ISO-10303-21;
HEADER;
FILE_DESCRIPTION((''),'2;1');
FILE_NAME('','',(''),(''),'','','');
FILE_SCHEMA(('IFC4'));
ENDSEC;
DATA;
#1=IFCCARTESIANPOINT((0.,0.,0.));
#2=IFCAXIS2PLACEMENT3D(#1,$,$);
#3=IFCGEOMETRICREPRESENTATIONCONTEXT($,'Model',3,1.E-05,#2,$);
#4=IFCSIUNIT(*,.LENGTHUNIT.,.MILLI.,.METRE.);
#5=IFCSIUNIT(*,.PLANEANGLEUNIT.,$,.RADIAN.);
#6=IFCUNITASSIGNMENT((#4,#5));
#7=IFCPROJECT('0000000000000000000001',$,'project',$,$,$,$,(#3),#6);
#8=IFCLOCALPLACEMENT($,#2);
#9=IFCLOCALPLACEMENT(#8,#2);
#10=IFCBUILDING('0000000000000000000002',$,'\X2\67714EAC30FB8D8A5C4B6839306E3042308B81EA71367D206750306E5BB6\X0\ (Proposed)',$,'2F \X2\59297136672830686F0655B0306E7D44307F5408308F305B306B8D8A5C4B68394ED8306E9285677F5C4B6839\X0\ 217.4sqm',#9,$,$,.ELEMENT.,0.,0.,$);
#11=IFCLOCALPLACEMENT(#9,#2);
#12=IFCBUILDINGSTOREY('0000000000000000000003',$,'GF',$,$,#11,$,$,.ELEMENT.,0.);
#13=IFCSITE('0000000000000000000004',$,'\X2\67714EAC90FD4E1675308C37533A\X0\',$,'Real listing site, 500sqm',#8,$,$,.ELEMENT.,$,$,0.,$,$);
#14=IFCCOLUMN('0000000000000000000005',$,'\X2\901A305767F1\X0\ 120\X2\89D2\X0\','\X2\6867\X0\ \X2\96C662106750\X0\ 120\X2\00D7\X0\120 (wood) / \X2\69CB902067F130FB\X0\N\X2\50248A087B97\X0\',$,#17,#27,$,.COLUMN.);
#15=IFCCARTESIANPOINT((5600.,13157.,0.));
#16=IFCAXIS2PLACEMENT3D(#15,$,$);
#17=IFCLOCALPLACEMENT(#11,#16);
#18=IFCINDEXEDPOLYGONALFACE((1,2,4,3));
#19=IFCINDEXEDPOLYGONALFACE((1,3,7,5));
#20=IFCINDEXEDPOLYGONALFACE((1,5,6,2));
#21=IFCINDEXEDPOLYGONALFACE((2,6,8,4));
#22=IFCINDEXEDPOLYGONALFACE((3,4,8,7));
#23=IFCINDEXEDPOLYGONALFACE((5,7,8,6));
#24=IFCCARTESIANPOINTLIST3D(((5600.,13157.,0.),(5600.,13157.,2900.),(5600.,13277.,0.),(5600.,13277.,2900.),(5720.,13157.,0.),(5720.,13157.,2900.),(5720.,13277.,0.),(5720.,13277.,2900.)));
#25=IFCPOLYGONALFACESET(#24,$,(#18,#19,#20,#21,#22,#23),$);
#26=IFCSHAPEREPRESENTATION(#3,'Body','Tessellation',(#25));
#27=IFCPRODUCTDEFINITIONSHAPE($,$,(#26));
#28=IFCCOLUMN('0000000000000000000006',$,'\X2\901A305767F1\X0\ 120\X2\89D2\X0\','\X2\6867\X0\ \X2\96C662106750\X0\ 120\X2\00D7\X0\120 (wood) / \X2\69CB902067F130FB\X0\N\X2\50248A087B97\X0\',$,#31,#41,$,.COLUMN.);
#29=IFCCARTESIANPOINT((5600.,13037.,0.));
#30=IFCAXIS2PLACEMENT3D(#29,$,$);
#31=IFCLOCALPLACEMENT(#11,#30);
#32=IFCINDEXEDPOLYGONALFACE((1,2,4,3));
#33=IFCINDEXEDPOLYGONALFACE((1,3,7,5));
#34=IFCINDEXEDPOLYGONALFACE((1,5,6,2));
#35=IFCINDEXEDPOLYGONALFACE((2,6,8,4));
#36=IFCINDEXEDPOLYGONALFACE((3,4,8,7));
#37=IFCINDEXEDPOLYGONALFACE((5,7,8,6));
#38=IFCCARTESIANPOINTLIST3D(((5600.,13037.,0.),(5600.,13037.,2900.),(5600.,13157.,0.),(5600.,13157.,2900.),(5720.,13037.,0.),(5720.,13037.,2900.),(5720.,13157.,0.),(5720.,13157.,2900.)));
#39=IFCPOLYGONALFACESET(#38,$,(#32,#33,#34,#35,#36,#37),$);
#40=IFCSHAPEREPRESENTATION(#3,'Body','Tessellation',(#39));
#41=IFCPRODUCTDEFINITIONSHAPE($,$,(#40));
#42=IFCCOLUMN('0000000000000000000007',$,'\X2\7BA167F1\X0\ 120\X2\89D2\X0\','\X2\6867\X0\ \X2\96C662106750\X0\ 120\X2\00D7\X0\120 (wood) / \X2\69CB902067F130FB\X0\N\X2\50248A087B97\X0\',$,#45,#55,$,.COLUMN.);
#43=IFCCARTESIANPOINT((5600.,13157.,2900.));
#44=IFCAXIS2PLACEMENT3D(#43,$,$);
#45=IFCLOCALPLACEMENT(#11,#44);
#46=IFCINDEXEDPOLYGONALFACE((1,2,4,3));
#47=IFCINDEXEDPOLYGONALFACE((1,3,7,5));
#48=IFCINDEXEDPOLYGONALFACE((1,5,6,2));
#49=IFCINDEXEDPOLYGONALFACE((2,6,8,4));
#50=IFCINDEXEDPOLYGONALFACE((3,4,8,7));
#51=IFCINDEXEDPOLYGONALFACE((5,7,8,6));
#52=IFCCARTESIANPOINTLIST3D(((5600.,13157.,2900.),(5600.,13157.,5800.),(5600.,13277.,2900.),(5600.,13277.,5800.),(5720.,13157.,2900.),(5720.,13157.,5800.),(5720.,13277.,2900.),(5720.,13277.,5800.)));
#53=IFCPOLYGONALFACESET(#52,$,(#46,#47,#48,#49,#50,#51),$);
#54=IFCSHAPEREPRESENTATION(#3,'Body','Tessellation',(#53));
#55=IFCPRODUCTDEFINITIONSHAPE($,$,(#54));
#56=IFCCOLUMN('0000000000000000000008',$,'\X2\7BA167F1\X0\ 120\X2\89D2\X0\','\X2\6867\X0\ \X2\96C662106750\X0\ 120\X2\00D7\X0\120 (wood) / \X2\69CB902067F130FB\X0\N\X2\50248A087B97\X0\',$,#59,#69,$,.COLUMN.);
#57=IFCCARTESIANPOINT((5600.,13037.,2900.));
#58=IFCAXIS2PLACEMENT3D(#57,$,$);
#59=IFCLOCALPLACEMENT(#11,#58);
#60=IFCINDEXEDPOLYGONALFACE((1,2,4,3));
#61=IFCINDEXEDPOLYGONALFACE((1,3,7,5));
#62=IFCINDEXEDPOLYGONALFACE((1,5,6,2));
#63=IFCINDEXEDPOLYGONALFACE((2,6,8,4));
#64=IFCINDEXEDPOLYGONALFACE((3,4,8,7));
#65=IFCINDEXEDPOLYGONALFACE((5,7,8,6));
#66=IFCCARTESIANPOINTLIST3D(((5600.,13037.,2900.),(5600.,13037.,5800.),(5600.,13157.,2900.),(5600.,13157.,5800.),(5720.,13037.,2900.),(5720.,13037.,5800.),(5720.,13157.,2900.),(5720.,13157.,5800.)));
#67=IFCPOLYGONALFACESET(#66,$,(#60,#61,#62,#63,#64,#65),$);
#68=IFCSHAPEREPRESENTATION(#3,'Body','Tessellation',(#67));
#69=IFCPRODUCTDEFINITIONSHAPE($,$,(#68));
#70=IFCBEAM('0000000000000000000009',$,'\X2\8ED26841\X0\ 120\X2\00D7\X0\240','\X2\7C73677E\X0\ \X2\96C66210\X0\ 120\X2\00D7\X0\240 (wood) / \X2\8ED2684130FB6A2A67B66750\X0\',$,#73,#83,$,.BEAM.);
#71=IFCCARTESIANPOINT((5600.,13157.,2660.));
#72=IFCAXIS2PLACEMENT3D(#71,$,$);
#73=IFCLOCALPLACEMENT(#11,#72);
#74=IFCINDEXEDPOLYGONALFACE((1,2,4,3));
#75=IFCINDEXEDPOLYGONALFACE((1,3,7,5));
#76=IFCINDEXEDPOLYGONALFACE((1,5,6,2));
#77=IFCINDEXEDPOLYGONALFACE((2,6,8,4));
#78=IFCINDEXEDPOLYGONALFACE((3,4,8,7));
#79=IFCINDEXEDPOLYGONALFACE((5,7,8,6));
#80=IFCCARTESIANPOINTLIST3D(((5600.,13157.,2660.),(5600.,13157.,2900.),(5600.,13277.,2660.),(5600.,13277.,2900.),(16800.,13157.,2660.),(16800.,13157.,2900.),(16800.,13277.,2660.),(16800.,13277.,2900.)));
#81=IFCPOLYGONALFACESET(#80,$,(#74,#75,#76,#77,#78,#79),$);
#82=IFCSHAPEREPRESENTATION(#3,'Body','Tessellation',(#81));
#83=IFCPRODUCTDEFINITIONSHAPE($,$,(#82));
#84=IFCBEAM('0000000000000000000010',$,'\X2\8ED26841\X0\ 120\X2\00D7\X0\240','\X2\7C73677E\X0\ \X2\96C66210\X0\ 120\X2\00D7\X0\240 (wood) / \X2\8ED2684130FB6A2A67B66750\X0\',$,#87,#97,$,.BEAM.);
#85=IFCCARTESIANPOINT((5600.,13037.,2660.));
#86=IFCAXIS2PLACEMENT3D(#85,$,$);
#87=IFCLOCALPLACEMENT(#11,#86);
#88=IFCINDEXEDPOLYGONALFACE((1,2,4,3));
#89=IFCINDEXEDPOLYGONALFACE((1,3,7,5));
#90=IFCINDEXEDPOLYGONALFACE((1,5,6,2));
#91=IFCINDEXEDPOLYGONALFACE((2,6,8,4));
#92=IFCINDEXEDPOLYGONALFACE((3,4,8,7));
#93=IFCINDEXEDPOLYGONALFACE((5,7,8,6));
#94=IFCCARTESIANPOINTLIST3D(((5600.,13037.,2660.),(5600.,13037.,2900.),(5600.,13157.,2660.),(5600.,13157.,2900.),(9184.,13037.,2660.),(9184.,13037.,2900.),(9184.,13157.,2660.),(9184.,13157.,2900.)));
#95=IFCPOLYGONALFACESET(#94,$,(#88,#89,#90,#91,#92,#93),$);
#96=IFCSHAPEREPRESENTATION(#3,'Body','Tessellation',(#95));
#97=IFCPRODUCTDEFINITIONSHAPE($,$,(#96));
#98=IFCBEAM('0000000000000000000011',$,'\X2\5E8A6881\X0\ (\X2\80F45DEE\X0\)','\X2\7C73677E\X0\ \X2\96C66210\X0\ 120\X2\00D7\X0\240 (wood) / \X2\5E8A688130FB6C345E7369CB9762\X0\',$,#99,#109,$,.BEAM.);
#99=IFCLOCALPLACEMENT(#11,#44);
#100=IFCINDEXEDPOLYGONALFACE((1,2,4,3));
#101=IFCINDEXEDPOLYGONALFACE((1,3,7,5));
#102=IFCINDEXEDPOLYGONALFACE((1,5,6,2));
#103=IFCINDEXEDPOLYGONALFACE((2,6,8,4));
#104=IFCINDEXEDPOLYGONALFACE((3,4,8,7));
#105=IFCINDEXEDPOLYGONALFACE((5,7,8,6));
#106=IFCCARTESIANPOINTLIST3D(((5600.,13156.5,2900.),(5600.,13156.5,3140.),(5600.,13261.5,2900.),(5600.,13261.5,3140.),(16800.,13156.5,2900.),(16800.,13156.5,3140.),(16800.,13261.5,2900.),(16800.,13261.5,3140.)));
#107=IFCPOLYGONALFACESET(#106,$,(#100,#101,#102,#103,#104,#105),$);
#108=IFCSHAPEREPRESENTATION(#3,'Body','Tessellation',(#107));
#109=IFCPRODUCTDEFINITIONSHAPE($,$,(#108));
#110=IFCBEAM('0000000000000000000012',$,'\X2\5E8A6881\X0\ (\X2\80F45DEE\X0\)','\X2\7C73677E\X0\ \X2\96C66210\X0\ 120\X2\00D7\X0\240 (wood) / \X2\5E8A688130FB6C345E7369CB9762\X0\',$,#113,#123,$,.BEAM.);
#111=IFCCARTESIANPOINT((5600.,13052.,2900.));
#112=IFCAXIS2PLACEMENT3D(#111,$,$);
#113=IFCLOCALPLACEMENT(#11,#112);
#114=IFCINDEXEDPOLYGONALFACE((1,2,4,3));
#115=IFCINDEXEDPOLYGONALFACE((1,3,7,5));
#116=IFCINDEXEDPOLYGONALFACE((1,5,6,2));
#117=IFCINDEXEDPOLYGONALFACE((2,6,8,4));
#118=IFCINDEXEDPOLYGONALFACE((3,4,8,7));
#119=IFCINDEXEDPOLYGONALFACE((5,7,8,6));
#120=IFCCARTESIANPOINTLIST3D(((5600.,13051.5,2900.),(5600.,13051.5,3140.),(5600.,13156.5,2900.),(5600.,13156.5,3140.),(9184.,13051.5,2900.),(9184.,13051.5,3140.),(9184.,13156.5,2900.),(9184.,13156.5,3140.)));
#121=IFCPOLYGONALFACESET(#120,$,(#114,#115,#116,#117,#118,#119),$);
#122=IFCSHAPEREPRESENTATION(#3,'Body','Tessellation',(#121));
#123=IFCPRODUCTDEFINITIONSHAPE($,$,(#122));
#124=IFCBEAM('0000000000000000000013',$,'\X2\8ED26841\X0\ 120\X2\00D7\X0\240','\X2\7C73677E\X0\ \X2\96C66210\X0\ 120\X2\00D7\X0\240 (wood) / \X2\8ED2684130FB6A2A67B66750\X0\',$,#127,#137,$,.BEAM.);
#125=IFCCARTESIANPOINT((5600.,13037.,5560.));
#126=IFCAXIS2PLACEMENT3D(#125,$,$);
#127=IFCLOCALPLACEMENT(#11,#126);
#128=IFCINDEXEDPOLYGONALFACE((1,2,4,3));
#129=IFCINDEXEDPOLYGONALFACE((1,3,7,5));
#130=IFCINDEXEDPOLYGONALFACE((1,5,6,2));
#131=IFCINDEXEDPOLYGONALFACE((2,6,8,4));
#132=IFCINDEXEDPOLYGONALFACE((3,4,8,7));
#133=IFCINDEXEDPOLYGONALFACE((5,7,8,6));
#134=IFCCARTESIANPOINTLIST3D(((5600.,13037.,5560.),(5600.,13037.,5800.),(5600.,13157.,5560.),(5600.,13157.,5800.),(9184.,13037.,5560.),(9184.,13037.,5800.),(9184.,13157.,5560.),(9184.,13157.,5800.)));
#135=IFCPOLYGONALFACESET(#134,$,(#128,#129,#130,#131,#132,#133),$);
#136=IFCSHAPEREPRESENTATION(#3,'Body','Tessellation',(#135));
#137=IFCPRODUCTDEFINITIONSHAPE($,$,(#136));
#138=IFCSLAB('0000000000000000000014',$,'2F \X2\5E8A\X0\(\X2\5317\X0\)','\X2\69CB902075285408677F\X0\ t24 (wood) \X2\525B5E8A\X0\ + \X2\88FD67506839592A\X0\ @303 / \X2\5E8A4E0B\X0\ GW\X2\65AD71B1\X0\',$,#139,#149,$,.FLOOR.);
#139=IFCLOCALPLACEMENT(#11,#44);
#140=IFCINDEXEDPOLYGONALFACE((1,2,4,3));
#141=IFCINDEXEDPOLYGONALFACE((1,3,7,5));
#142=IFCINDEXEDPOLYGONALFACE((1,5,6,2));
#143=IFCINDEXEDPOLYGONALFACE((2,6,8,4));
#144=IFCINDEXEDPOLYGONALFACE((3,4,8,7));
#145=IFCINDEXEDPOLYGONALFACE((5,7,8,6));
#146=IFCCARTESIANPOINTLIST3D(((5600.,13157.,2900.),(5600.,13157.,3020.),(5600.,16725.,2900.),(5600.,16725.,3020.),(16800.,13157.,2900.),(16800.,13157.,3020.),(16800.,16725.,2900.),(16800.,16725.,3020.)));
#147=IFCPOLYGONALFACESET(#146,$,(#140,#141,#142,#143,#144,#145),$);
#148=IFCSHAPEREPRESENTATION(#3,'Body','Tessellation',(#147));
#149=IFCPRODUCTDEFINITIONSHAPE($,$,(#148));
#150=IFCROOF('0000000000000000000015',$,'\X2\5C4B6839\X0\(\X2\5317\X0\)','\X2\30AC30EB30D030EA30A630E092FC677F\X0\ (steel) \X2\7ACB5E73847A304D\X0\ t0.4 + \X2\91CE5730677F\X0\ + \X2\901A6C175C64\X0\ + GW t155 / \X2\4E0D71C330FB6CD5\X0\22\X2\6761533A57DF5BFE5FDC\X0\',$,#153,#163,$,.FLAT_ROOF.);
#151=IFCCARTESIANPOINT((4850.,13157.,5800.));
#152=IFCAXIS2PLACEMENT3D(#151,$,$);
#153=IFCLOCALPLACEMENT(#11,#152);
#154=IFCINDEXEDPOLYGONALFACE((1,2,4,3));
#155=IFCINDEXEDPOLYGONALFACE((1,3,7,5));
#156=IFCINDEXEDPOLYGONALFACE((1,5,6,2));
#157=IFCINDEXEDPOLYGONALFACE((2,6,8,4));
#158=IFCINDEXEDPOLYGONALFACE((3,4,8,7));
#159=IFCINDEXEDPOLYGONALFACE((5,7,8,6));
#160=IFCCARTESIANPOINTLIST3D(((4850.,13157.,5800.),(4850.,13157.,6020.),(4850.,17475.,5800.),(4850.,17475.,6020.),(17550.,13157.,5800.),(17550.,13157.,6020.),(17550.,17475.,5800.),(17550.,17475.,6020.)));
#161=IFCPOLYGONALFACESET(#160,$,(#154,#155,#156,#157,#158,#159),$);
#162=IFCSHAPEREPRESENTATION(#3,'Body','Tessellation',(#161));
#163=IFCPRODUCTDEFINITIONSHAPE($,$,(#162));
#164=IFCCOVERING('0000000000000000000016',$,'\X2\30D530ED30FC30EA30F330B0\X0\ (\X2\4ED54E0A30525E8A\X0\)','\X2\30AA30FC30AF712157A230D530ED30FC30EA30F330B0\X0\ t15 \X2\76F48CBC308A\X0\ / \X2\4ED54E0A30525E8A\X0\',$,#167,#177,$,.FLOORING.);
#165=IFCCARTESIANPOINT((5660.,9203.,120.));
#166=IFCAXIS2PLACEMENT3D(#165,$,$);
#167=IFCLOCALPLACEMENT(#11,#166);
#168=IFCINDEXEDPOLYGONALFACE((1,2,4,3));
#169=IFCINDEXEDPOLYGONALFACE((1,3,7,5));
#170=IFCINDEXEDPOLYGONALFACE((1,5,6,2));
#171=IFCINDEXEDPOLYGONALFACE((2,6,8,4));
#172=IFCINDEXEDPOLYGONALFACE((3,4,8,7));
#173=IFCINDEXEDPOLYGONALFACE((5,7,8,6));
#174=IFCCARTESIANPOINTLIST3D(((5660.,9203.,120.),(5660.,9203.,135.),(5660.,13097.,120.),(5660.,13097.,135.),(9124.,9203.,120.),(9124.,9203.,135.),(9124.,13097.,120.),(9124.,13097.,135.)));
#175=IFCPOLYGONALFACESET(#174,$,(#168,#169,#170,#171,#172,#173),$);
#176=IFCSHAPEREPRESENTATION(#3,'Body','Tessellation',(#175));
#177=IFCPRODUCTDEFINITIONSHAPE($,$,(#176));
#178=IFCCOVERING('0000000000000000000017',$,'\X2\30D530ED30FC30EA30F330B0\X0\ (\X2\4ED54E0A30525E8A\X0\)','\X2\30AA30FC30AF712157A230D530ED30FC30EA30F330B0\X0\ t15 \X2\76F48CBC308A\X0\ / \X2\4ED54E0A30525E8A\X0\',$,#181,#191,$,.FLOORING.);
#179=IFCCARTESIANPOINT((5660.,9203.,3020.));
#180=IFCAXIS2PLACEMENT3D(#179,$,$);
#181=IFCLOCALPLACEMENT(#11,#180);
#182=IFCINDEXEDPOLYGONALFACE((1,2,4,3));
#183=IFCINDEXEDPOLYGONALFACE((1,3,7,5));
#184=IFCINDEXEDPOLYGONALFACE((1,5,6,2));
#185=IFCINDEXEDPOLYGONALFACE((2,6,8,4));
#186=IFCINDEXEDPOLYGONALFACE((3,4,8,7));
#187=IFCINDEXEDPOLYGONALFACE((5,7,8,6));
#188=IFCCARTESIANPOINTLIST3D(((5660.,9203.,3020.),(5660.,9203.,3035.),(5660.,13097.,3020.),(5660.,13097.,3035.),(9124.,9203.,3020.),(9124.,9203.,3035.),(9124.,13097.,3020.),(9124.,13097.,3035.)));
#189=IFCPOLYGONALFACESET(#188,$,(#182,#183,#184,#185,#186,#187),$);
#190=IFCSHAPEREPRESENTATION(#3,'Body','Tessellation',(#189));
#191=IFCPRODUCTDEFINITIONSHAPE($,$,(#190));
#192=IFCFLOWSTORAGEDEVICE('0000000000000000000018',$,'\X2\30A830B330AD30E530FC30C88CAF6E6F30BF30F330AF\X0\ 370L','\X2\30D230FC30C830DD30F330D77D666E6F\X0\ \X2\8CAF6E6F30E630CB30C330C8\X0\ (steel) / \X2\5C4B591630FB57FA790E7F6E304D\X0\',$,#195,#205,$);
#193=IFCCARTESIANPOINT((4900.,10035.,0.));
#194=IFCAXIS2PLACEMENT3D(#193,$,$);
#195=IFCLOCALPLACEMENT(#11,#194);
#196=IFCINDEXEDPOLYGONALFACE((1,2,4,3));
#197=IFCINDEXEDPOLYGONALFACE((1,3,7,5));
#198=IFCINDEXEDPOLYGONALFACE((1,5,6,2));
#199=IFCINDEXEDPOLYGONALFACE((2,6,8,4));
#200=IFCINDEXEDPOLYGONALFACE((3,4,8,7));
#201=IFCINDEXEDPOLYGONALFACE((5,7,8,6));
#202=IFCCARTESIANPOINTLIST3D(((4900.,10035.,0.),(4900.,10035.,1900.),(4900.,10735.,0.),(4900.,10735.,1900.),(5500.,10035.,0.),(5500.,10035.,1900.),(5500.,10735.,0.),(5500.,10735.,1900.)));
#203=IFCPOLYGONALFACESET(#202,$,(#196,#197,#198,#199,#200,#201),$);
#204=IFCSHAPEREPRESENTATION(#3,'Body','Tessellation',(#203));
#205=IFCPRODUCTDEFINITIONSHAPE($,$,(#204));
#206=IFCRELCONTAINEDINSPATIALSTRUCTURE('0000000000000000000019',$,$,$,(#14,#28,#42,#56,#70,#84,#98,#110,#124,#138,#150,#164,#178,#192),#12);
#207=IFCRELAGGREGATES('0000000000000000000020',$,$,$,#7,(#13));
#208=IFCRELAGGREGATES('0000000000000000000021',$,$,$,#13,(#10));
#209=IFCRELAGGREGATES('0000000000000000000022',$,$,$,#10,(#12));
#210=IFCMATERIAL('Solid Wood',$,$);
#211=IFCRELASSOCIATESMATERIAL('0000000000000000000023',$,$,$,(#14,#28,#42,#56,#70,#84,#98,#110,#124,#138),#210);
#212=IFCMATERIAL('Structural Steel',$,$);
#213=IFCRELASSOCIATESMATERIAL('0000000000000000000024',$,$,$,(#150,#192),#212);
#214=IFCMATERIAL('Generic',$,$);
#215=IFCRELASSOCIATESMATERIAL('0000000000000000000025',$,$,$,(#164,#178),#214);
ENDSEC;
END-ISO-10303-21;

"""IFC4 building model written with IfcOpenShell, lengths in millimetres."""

from ifc_helpers import new_model, si_unit, frame, frame_2d, origin, place, context, project, spatial, rectangle, extrude, material, element, save


model = new_model("IFC4")

# Units and contexts
model_context = context("Model", 3, precision=1e-05, world=origin())
ifc_project = project(units=[si_unit("LENGTHUNIT", "METRE", prefix="MILLI"), si_unit("PLANEANGLEUNIT", "RADIAN")], contexts=[model_context])

# Site, building, storey
site_placement = place(None, origin())
site = spatial("IfcSite", under=ifc_project, at=site_placement, Name="東京都世田谷区", ObjectType="Real listing site, 500sqm", CompositionType="ELEMENT", RefElevation=0.0)
building_placement = place(site_placement, origin())
building = spatial("IfcBuilding", under=site, at=building_placement, Name="東京・越屋根のある自然素材の家 (Proposed)", ObjectType="2F 天然木と漆喰の組み合わせに越屋根付の銅板屋根 217.4sqm", CompositionType="ELEMENT", ElevationOfRefHeight=0.0, ElevationOfTerrain=0.0)
storey_placement = place(building_placement, origin())
storey = spatial("IfcBuildingStorey", under=building, at=storey_placement, Name="GF", CompositionType="ELEMENT", Elevation=0.0)

# Columns
ifc_material_1 = material(Name="Solid Wood")
column_1_placement = place(storey_placement, frame((5600.0, 13157.0, 0.0)))
element("IfcColumn", 1, at=column_1_placement, inside=storey, material=ifc_material_1, Name="通し柱 120角", Description="桧 集成材 120×120 (wood) / 構造柱・N値計算", PredefinedType="COLUMN", context=model_context, shape_type="SweptSolid", body=[
    extrude(rectangle(XDim=120.0, YDim=120.0, at=frame_2d((60.0, 60.0))), frame((5600.0, 13157.0, 0.0)), (0.0, 0.0, 1.0), 2900.0),
])
column_2_placement = place(storey_placement, frame((5600.0, 13037.0, 0.0)))
element("IfcColumn", 2, at=column_2_placement, inside=storey, material=ifc_material_1, Name="通し柱 120角", Description="桧 集成材 120×120 (wood) / 構造柱・N値計算", PredefinedType="COLUMN", context=model_context, shape_type="SweptSolid", body=[
    extrude(rectangle(XDim=120.0, YDim=120.0, at=frame_2d((60.0, 60.0))), frame((5600.0, 13037.0, 0.0)), (0.0, 0.0, 1.0), 2900.0),
])
column_3_placement = place(storey_placement, frame((5600.0, 13157.0, 2900.0)))
element("IfcColumn", 3, at=column_3_placement, inside=storey, material=ifc_material_1, Name="管柱 120角", Description="桧 集成材 120×120 (wood) / 構造柱・N値計算", PredefinedType="COLUMN", context=model_context, shape_type="SweptSolid", body=[
    extrude(rectangle(XDim=120.0, YDim=120.0, at=frame_2d((60.0, 60.0))), frame((5600.0, 13157.0, 2900.0)), (0.0, 0.0, 1.0), 2900.0),
])
column_4_placement = place(storey_placement, frame((5600.0, 13037.0, 2900.0)))
element("IfcColumn", 4, at=column_4_placement, inside=storey, material=ifc_material_1, Name="管柱 120角", Description="桧 集成材 120×120 (wood) / 構造柱・N値計算", PredefinedType="COLUMN", context=model_context, shape_type="SweptSolid", body=[
    extrude(rectangle(XDim=120.0, YDim=120.0, at=frame_2d((60.0, 60.0))), frame((5600.0, 13037.0, 2900.0)), (0.0, 0.0, 1.0), 2900.0),
])

# Beams
beam_1_placement = place(storey_placement, frame((5600.0, 13157.0, 2660.0)))
element("IfcBeam", 5, at=beam_1_placement, inside=storey, material=ifc_material_1, Name="軒桁 120×240", Description="米松 集成 120×240 (wood) / 軒桁・横架材", PredefinedType="BEAM", context=model_context, shape_type="SweptSolid", body=[
    extrude(rectangle(XDim=11200.0, YDim=120.0, at=frame_2d((5600.0, 60.0))), frame((5600.0, 13157.0, 2660.0)), (0.0, 0.0, 1.0), 240.0),
])
beam_2_placement = place(storey_placement, frame((5600.0, 13037.0, 2660.0)))
element("IfcBeam", 6, at=beam_2_placement, inside=storey, material=ifc_material_1, Name="軒桁 120×240", Description="米松 集成 120×240 (wood) / 軒桁・横架材", PredefinedType="BEAM", context=model_context, shape_type="SweptSolid", body=[
    extrude(rectangle(XDim=3584.0, YDim=120.0, at=frame_2d((1792.0, 60.0))), frame((5600.0, 13037.0, 2660.0)), (0.0, 0.0, 1.0), 240.0),
])
beam_3_placement = place(storey_placement, frame((5600.0, 13157.0, 2900.0)))
element("IfcBeam", 7, at=beam_3_placement, inside=storey, material=ifc_material_1, Name="床梁 (胴差)", Description="米松 集成 120×240 (wood) / 床梁・水平構面", PredefinedType="BEAM", context=model_context, shape_type="SweptSolid", body=[
    extrude(rectangle(XDim=11200.0, YDim=105.0, at=frame_2d((5600.0, 52.0))), frame((5600.0, 13157.0, 2900.0)), (0.0, 0.0, 1.0), 240.0),
])
beam_4_placement = place(storey_placement, frame((5600.0, 13052.0, 2900.0)))
element("IfcBeam", 8, at=beam_4_placement, inside=storey, material=ifc_material_1, Name="床梁 (胴差)", Description="米松 集成 120×240 (wood) / 床梁・水平構面", PredefinedType="BEAM", context=model_context, shape_type="SweptSolid", body=[
    extrude(rectangle(XDim=3584.0, YDim=105.0, at=frame_2d((1792.0, 52.0))), frame((5600.0, 13052.0, 2900.0)), (0.0, 0.0, 1.0), 240.0),
])
beam_5_placement = place(storey_placement, frame((5600.0, 13037.0, 5560.0)))
element("IfcBeam", 9, at=beam_5_placement, inside=storey, material=ifc_material_1, Name="軒桁 120×240", Description="米松 集成 120×240 (wood) / 軒桁・横架材", PredefinedType="BEAM", context=model_context, shape_type="SweptSolid", body=[
    extrude(rectangle(XDim=3584.0, YDim=120.0, at=frame_2d((1792.0, 60.0))), frame((5600.0, 13037.0, 5560.0)), (0.0, 0.0, 1.0), 240.0),
])

# Slab
slab_1_placement = place(storey_placement, frame((5600.0, 13157.0, 2900.0)))
element("IfcSlab", 10, at=slab_1_placement, inside=storey, material=ifc_material_1, Name="2F 床(北)", Description="構造用合板 t24 (wood) 剛床 + 製材根太 @303 / 床下 GW断熱", PredefinedType="FLOOR", context=model_context, shape_type="SweptSolid", body=[
    extrude(rectangle(XDim=11200.0, YDim=3568.0, at=frame_2d((5600.0, 1784.0))), frame((5600.0, 13157.0, 2900.0)), (0.0, 0.0, 1.0), 120.0),
])

# Roof
ifc_material_2 = material(Name="Structural Steel")
for number, where, name in (
    (11, (4850.0, 13157.0, 5800.0), "屋根(北)"),
):
    element("IfcRoof", number, at=place(storey_placement, frame(where)), inside=storey, material=ifc_material_2, Name=name, Description="ガルバリウム鋼板 (steel) 立平葺き t0.4 + 野地板 + 通気層 + GW t155 / 不燃・法22条区域対応", PredefinedType="FLAT_ROOF", context=model_context, shape_type="SweptSolid", body=[
        extrude(rectangle(XDim=12700.0, YDim=4318.0, at=frame_2d((6350.0, 2159.0))), frame((4850.0, 13157.0, 5800.0)), (0.0, 0.0, 1.0), 220.0),
    ])

# Coverings
ifc_material_3 = material(Name="Generic")
covering_1_placement = place(storey_placement, frame((5660.0, 9203.0, 120.0)))
element("IfcCovering", 12, at=covering_1_placement, inside=storey, material=ifc_material_3, Name="フローリング (仕上げ床)", Description="オーク無垢フローリング t15 直貼り / 仕上げ床", PredefinedType="FLOORING", context=model_context, shape_type="SweptSolid", body=[
    extrude(rectangle(XDim=3464.0, YDim=3894.0, at=frame_2d((1732.0, 1947.0))), frame((5660.0, 9203.0, 120.0)), (0.0, 0.0, 1.0), 15.0),
])
covering_2_placement = place(storey_placement, frame((5660.0, 9203.0, 3020.0)))
element("IfcCovering", 13, at=covering_2_placement, inside=storey, material=ifc_material_3, Name="フローリング (仕上げ床)", Description="オーク無垢フローリング t15 直貼り / 仕上げ床", PredefinedType="FLOORING", context=model_context, shape_type="SweptSolid", body=[
    extrude(rectangle(XDim=3464.0, YDim=3894.0, at=frame_2d((1732.0, 1947.0))), frame((5660.0, 9203.0, 3020.0)), (0.0, 0.0, 1.0), 15.0),
])

# Flow storage device
flow_storage_device_placement = place(storey_placement, frame((4900.0, 10035.0, 0.0)))
element("IfcFlowStorageDevice", 14, at=flow_storage_device_placement, inside=storey, material=ifc_material_2, Name="エコキュート貯湯タンク 370L", Description="ヒートポンプ給湯 貯湯ユニット (steel) / 屋外・基礎置き", context=model_context, shape_type="SweptSolid", body=[
    extrude(rectangle(XDim=600.0, YDim=700.0, at=frame_2d((300.0, 350.0))), frame((4900.0, 10035.0, 0.0)), (0.0, 0.0, 1.0), 1900.0),
])

save(model, "model.ifc")
